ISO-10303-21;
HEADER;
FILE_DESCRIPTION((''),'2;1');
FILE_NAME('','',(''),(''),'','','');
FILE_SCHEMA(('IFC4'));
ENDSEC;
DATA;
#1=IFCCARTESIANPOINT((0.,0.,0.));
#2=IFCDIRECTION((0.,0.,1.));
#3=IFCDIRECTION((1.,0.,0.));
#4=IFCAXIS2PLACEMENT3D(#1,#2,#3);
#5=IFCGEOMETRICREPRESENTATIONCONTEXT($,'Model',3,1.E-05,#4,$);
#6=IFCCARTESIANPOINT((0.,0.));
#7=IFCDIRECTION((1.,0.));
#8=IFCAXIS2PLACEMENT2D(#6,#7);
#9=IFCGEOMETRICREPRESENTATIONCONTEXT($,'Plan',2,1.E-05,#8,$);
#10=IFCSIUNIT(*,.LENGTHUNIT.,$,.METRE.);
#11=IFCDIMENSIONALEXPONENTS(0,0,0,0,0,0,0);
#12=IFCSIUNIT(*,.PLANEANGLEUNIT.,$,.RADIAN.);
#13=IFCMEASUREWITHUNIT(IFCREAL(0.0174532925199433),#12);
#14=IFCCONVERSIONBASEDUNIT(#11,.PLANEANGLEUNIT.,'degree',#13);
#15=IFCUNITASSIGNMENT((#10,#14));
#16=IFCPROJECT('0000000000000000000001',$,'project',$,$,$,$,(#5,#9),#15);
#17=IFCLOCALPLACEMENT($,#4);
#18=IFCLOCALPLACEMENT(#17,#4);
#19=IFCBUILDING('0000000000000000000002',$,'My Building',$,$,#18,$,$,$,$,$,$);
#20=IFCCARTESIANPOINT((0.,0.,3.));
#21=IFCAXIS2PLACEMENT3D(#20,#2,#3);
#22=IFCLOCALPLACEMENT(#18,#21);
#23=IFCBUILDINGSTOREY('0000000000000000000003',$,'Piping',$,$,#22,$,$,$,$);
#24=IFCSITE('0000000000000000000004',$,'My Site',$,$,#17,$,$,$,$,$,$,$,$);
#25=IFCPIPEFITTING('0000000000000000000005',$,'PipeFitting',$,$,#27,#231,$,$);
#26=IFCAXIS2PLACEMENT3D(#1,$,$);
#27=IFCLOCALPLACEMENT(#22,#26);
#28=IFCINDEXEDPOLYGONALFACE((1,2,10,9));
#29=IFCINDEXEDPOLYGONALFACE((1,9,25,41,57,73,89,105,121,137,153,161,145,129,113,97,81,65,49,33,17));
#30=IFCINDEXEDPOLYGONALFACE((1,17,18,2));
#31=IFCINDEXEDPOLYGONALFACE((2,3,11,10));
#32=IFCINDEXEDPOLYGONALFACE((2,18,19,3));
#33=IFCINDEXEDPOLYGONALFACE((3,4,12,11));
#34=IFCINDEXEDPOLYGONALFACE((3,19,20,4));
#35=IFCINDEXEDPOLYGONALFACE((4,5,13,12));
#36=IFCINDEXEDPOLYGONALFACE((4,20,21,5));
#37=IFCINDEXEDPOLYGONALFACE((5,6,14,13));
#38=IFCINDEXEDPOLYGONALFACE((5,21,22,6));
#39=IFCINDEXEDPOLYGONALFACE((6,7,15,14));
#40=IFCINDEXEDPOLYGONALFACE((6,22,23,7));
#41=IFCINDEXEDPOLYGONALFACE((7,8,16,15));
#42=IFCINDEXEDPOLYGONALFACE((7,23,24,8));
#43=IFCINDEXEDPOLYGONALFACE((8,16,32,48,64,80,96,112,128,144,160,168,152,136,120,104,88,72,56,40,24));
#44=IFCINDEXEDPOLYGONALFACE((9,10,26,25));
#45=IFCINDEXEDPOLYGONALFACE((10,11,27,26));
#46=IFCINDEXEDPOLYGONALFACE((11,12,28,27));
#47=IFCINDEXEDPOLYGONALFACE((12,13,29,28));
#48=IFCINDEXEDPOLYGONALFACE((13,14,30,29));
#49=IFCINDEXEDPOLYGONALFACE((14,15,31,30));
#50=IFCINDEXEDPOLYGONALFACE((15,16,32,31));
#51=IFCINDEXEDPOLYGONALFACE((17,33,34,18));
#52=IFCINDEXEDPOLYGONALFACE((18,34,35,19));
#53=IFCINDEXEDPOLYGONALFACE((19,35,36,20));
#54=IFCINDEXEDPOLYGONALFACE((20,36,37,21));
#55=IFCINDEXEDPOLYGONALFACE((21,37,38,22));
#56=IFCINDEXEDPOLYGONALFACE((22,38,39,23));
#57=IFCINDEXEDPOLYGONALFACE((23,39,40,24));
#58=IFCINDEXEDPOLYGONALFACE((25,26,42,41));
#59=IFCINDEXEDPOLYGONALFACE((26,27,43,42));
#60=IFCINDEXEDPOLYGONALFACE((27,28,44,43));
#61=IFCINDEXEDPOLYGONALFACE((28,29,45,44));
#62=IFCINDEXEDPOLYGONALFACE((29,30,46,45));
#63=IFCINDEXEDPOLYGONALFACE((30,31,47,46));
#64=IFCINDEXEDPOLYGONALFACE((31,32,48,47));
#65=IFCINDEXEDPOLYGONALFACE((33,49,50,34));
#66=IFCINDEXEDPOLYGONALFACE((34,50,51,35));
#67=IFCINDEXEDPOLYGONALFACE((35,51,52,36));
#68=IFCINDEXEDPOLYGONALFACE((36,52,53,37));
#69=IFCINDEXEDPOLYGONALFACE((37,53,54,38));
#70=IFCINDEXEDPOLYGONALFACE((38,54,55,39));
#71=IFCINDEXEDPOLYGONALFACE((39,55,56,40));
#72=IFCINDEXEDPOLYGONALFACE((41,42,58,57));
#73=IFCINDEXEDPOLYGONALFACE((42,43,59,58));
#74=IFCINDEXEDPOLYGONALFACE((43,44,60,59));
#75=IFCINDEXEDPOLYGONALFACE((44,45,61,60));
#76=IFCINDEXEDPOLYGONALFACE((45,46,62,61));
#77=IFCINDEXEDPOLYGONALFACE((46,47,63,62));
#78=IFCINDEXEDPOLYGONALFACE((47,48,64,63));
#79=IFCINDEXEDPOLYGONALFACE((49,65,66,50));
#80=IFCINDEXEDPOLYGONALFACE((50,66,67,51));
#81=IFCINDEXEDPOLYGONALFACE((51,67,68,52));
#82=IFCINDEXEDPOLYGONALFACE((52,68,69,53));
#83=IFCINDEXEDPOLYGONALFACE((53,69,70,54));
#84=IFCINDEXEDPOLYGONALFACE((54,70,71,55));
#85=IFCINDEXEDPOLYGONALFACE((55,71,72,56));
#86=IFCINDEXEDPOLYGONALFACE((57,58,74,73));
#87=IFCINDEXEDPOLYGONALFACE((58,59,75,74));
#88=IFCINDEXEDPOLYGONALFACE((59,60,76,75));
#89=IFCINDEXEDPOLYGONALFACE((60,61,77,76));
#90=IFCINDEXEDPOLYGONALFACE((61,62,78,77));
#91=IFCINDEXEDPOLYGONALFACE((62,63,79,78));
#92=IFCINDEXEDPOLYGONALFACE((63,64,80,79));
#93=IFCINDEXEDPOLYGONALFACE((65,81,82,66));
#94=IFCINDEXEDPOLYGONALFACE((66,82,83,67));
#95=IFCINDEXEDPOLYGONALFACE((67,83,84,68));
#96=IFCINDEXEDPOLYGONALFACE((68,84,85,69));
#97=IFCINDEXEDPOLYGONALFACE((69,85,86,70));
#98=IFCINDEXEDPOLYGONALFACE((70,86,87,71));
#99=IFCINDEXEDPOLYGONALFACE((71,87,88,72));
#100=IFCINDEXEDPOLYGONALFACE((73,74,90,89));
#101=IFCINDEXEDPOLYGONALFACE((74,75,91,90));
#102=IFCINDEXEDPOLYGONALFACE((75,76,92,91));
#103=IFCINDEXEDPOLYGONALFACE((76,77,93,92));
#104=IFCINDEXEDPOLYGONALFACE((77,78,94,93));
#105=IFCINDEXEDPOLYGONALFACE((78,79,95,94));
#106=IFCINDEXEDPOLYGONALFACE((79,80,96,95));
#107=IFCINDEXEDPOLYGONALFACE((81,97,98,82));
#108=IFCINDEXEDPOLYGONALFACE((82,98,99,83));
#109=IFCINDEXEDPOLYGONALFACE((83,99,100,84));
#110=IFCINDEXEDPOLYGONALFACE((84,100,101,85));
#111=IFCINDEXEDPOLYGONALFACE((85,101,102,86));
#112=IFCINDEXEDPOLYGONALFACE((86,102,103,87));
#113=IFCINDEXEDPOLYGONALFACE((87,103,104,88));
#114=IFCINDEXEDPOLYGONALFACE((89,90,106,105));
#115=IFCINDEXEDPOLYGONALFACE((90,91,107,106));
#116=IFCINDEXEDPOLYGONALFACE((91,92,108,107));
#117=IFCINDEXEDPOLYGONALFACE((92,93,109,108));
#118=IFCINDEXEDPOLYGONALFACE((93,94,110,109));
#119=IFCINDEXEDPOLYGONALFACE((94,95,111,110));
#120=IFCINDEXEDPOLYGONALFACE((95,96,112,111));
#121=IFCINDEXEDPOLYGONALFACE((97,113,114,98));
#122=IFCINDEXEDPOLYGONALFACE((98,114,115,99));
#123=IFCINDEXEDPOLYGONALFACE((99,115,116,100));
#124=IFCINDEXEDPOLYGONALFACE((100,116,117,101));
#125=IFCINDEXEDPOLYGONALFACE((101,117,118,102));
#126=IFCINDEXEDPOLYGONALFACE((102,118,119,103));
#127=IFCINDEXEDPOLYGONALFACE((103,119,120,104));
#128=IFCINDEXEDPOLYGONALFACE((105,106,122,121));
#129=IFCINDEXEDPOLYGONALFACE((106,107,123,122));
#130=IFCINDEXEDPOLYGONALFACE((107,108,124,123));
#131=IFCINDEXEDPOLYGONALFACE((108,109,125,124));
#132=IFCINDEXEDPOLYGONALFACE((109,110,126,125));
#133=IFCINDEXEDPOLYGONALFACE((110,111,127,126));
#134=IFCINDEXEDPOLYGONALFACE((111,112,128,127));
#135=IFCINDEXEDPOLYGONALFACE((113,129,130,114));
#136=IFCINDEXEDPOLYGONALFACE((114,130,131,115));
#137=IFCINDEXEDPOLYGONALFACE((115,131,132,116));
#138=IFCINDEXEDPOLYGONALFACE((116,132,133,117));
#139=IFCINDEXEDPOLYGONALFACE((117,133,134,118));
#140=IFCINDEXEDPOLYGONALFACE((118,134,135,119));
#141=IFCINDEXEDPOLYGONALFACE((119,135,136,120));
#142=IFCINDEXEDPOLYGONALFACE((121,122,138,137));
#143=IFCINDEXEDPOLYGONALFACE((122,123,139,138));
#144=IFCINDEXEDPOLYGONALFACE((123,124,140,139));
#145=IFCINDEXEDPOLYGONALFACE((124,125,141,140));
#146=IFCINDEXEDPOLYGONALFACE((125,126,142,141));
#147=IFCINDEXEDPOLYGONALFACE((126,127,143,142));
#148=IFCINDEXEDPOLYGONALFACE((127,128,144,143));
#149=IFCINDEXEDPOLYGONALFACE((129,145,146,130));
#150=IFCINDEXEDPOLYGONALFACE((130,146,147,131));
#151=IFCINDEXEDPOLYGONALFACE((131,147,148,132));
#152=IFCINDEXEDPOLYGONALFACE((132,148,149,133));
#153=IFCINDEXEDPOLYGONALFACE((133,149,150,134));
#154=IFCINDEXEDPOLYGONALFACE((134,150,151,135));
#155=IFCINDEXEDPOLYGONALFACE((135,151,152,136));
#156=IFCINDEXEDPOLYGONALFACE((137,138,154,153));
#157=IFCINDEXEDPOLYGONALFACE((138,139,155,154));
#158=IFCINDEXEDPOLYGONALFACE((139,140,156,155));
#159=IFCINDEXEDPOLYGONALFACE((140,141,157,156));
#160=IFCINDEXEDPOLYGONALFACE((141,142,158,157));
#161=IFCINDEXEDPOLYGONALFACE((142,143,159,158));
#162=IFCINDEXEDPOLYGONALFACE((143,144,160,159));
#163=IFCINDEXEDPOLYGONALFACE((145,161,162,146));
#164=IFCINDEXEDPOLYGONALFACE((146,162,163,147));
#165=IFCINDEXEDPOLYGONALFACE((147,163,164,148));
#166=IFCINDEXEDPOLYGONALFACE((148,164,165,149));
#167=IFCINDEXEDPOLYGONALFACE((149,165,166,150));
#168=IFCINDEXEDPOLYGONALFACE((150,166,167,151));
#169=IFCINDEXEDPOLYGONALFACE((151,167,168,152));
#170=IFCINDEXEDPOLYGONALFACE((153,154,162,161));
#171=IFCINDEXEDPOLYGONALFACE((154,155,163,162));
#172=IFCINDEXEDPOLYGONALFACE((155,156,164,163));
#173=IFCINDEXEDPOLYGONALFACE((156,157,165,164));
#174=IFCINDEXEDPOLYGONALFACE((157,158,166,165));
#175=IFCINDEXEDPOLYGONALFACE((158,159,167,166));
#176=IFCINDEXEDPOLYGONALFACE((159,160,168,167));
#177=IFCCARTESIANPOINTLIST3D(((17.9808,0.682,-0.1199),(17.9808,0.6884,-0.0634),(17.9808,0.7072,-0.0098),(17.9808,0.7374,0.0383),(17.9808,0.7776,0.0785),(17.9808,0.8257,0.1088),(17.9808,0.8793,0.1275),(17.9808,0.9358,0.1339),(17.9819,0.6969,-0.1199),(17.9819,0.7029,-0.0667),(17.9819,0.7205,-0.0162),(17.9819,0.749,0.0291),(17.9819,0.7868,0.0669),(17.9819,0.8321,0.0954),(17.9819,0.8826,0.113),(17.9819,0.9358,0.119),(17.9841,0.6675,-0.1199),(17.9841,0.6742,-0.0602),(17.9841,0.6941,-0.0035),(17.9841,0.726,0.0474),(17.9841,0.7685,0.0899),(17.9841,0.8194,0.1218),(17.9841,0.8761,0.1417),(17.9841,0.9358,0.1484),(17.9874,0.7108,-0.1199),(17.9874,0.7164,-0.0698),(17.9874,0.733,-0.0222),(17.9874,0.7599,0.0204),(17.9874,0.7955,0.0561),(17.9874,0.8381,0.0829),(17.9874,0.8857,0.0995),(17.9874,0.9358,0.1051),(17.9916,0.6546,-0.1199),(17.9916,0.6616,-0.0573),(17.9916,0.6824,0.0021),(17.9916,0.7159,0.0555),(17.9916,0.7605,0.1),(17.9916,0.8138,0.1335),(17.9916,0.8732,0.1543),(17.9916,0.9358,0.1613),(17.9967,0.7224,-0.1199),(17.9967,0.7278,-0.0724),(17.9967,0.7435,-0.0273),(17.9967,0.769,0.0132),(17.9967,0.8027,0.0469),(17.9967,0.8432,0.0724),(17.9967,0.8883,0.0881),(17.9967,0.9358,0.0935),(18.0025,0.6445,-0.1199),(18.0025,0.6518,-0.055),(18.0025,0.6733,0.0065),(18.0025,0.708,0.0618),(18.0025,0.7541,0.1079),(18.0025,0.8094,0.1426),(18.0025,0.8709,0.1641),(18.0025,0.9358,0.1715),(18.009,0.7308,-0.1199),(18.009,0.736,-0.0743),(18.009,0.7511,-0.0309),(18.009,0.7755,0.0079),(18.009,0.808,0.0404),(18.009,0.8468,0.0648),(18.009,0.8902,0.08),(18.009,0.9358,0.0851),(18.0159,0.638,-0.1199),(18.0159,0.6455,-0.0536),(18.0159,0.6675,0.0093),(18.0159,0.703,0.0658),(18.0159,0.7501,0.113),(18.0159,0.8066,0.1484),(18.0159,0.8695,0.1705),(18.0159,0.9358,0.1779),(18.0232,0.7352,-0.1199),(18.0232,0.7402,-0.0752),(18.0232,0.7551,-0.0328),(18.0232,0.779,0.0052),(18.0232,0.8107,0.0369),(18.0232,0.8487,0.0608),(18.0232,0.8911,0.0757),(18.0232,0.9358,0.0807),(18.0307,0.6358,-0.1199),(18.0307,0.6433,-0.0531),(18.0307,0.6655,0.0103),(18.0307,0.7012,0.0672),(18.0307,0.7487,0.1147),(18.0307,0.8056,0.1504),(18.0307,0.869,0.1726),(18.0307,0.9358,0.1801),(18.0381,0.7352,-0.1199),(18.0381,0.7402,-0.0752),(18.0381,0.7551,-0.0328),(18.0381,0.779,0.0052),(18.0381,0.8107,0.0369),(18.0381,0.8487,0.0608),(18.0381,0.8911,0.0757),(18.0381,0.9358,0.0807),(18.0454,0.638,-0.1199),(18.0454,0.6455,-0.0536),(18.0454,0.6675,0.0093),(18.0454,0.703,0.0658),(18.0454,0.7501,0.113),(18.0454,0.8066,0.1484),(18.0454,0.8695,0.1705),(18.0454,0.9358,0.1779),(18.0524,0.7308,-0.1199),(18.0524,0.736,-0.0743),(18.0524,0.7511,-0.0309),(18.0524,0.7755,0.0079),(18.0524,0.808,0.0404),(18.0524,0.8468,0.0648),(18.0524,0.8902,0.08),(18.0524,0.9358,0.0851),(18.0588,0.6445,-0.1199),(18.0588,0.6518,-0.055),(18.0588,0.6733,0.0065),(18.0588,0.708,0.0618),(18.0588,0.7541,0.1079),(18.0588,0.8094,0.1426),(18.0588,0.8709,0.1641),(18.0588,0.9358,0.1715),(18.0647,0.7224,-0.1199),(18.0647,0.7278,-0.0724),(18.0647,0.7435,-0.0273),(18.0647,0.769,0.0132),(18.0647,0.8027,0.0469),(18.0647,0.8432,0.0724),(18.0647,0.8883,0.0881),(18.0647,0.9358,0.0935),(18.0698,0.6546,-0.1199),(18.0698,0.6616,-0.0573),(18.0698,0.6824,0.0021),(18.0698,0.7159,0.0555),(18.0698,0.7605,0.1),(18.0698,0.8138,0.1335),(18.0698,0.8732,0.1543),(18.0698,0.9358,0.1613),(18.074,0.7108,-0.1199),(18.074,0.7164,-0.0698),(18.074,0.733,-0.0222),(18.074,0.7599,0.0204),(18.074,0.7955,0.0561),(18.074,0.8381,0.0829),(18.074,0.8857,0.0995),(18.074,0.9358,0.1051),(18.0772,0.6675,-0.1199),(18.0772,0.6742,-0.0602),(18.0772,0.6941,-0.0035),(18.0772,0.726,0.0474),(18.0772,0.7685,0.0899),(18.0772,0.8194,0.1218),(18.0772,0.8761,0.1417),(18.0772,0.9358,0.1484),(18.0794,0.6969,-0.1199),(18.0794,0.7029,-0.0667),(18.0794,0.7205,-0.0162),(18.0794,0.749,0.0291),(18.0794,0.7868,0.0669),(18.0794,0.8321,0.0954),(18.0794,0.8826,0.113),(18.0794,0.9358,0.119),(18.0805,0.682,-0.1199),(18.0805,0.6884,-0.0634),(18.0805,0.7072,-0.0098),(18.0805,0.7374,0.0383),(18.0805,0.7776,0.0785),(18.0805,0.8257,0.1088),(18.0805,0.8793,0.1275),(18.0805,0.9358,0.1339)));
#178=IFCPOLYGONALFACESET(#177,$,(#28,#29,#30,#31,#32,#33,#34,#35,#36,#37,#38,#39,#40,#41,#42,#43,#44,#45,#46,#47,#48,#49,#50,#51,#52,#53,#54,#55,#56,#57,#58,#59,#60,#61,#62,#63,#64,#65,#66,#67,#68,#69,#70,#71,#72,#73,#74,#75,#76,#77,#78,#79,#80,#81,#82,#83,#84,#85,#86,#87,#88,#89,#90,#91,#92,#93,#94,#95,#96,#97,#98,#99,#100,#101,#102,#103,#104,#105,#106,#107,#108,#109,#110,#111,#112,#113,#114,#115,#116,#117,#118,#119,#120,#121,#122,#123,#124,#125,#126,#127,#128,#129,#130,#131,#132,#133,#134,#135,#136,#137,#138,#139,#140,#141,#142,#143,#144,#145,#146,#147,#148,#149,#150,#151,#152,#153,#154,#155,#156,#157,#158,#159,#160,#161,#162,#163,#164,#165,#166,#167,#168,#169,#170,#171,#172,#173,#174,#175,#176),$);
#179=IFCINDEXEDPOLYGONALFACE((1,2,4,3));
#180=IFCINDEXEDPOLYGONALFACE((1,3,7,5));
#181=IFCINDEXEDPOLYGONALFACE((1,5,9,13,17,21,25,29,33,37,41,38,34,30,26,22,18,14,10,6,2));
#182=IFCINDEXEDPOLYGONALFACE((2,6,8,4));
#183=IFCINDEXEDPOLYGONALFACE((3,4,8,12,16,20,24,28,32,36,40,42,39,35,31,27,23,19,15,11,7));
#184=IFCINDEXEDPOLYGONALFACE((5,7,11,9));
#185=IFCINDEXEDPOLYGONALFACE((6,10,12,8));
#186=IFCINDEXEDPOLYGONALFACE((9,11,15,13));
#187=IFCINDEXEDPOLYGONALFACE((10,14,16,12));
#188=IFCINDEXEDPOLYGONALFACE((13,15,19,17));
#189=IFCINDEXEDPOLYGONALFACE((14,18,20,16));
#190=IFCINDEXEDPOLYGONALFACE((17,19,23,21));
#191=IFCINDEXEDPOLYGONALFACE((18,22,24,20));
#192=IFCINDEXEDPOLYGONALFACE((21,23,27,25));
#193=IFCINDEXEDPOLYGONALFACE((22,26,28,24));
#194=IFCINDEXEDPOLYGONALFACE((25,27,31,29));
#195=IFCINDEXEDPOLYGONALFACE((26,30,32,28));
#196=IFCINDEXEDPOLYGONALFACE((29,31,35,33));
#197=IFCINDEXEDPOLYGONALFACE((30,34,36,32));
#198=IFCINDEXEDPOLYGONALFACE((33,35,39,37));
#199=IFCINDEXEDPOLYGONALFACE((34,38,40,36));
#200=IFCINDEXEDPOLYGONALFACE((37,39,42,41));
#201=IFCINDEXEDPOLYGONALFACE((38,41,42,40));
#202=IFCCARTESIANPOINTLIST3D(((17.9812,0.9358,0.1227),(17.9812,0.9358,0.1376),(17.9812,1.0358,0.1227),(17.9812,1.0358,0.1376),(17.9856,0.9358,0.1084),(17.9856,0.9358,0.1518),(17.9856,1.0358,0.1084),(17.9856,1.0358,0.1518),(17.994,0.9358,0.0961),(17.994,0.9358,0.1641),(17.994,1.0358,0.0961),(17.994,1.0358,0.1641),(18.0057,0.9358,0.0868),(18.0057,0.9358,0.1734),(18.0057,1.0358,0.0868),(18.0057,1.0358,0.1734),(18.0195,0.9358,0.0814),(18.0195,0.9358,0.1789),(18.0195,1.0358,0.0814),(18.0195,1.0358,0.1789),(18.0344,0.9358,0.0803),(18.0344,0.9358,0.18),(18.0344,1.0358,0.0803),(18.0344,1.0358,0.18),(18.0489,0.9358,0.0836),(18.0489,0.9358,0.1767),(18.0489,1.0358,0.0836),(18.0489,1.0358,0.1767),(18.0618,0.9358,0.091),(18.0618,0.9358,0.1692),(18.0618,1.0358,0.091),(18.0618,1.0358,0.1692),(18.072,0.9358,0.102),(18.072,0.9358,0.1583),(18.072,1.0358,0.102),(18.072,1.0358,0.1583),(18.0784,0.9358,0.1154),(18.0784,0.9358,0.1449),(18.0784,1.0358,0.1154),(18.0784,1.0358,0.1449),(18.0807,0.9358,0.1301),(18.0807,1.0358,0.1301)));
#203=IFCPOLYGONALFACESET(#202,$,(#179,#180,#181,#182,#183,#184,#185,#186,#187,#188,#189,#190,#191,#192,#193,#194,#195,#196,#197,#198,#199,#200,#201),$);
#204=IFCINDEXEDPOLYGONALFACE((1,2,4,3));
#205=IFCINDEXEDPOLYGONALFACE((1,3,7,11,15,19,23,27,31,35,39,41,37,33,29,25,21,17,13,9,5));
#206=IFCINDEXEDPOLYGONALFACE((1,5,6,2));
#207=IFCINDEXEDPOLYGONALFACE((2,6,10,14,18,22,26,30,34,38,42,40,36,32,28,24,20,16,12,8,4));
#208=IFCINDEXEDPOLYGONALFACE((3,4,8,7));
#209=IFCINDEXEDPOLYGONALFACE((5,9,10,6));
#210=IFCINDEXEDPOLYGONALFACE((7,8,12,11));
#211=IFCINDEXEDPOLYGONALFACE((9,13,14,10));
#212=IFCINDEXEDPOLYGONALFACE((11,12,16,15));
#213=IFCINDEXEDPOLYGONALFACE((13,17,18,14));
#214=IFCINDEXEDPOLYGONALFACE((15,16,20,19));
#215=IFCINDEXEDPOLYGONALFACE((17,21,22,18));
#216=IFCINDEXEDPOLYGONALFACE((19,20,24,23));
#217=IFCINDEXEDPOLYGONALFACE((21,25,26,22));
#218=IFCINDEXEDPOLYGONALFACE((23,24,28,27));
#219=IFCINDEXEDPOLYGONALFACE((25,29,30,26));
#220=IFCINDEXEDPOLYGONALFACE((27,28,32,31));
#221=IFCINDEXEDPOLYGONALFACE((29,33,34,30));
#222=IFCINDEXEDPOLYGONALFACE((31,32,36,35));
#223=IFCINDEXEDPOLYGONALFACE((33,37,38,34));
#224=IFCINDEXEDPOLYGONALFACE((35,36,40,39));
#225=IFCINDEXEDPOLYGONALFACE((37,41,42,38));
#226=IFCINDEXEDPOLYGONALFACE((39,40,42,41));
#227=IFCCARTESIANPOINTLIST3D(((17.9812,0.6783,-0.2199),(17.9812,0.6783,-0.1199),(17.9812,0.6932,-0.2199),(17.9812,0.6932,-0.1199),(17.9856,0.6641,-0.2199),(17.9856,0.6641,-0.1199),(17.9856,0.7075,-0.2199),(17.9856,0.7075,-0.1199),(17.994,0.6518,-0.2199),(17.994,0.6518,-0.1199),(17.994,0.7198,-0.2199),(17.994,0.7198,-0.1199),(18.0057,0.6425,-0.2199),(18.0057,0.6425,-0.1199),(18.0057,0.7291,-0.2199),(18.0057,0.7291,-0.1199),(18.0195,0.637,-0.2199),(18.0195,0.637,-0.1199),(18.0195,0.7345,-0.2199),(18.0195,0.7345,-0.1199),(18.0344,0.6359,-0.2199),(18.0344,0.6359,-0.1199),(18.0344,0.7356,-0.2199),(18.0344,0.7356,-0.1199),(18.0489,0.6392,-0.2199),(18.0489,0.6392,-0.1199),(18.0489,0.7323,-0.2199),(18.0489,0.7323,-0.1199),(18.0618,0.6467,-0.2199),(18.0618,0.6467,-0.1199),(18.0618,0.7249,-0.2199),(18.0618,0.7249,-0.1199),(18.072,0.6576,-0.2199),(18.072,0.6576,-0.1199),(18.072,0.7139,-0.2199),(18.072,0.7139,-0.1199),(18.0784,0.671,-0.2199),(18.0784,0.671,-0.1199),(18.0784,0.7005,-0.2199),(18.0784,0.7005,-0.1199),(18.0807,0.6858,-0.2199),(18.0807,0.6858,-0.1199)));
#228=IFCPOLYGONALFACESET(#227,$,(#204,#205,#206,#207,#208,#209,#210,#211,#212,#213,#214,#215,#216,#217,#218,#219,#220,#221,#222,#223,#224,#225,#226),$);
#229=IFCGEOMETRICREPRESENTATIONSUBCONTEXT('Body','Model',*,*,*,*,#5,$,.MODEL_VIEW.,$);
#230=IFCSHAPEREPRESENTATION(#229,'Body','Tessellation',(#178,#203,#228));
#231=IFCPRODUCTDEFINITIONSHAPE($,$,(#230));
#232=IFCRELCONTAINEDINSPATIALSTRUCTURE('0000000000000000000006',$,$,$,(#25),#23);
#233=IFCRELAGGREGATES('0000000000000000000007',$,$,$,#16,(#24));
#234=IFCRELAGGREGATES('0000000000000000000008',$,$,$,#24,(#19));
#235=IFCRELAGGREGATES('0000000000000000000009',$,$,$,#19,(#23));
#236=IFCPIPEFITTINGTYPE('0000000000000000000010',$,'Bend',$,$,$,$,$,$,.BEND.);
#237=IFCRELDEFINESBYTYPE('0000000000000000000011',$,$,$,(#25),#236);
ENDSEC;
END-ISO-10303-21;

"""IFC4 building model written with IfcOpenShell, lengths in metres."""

from ifc_helpers import new_model, entity, si_unit, converted_unit, frame, origin_with_axes, origin_2d_with_axis, place, context, subcontext, project, spatial, circle, extrude, source, transform, mapped, type_object, type_shapes, element, save


model = new_model("IFC4")

# Units and contexts
model_context = context("Model", 3, precision=1e-05, world=origin_with_axes())
plan_context = context("Plan", 2, precision=1e-05, world=origin_2d_with_axis())
body_context = subcontext(model_context, "Body", "Model", "MODEL_VIEW")
ifc_project = project(units=[si_unit("LENGTHUNIT", "METRE"), converted_unit("PLANEANGLEUNIT", "degree", entity("IfcReal", 0.0174532925199433), si_unit("PLANEANGLEUNIT", "RADIAN"), dimensions=[0, 0, 0, 0, 0, 0, 0])], contexts=[model_context, plan_context])

# Site, building, storey
site_placement = place(None, origin_with_axes())
site = spatial("IfcSite", under=ifc_project, at=site_placement, Name="My Site")
building_placement = place(site_placement, origin_with_axes())
building = spatial("IfcBuilding", under=site, at=building_placement, Name="My Building")
storey_placement = place(building_placement, frame((0.0, 0.0, 3.0), z_axis=(0.0, 0.0, 1.0), x_axis=(1.0, 0.0, 0.0)))
storey = spatial("IfcBuildingStorey", under=building, at=storey_placement, Name="Piping")

# Pipe fitting
pipe_fitting_type_1 = type_object("IfcPipeFittingType", Name="Bend", PredefinedType="BEND")
shared_shape_1 = source(origin_with_axes(), body_context, "Body", "SolidModel", [
    entity("IfcSweptDiskSolid", entity("IfcIndexedPolyCurve", entity("IfcCartesianPointList3D", [[0.0, 0.0, 0.1], [0.0, -0.0732, 0.2768], [0.0, -0.25, 0.35]]), [entity("IfcArcIndex", [1, 2, 3])]), 0.05),
    extrude(circle(Radius=0.05), origin_with_axes(), (0.0, 0.0, 1.0), 0.1),
    extrude(circle(Radius=0.05), frame((0.0, -0.25, 0.35), z_axis=(0.0, -1.0, -0.000015), x_axis=(1.0, 0.0, 0.0)), (0.0, 0.0, 1.0), 0.1),
])
type_shapes(pipe_fitting_type_1, [shared_shape_1])
for number, where, z_axis, x_axis, name in (
    (1, (18.0307, 1.0358, 0.1301), (0.0, -1.0, 0.000015), (1.0, 0.0, 0.0), "PipeFitting"),
):
    element("IfcPipeFitting", number, at=place(storey_placement, frame(where, z_axis=z_axis, x_axis=x_axis)), inside=storey, type_object=pipe_fitting_type_1, Name=name, context=body_context, shape_type="MappedRepresentation", body=[
        mapped(shared_shape_1, transform((0.0, 0.0, 0.0), x_axis=(1.0, 0.0, 0.0), y_axis=(0.0, 1.0, 0.0), z_axis=(0.0, 0.0, 1.0), scale=1.0)),
    ])

save(model, "model.ifc")
